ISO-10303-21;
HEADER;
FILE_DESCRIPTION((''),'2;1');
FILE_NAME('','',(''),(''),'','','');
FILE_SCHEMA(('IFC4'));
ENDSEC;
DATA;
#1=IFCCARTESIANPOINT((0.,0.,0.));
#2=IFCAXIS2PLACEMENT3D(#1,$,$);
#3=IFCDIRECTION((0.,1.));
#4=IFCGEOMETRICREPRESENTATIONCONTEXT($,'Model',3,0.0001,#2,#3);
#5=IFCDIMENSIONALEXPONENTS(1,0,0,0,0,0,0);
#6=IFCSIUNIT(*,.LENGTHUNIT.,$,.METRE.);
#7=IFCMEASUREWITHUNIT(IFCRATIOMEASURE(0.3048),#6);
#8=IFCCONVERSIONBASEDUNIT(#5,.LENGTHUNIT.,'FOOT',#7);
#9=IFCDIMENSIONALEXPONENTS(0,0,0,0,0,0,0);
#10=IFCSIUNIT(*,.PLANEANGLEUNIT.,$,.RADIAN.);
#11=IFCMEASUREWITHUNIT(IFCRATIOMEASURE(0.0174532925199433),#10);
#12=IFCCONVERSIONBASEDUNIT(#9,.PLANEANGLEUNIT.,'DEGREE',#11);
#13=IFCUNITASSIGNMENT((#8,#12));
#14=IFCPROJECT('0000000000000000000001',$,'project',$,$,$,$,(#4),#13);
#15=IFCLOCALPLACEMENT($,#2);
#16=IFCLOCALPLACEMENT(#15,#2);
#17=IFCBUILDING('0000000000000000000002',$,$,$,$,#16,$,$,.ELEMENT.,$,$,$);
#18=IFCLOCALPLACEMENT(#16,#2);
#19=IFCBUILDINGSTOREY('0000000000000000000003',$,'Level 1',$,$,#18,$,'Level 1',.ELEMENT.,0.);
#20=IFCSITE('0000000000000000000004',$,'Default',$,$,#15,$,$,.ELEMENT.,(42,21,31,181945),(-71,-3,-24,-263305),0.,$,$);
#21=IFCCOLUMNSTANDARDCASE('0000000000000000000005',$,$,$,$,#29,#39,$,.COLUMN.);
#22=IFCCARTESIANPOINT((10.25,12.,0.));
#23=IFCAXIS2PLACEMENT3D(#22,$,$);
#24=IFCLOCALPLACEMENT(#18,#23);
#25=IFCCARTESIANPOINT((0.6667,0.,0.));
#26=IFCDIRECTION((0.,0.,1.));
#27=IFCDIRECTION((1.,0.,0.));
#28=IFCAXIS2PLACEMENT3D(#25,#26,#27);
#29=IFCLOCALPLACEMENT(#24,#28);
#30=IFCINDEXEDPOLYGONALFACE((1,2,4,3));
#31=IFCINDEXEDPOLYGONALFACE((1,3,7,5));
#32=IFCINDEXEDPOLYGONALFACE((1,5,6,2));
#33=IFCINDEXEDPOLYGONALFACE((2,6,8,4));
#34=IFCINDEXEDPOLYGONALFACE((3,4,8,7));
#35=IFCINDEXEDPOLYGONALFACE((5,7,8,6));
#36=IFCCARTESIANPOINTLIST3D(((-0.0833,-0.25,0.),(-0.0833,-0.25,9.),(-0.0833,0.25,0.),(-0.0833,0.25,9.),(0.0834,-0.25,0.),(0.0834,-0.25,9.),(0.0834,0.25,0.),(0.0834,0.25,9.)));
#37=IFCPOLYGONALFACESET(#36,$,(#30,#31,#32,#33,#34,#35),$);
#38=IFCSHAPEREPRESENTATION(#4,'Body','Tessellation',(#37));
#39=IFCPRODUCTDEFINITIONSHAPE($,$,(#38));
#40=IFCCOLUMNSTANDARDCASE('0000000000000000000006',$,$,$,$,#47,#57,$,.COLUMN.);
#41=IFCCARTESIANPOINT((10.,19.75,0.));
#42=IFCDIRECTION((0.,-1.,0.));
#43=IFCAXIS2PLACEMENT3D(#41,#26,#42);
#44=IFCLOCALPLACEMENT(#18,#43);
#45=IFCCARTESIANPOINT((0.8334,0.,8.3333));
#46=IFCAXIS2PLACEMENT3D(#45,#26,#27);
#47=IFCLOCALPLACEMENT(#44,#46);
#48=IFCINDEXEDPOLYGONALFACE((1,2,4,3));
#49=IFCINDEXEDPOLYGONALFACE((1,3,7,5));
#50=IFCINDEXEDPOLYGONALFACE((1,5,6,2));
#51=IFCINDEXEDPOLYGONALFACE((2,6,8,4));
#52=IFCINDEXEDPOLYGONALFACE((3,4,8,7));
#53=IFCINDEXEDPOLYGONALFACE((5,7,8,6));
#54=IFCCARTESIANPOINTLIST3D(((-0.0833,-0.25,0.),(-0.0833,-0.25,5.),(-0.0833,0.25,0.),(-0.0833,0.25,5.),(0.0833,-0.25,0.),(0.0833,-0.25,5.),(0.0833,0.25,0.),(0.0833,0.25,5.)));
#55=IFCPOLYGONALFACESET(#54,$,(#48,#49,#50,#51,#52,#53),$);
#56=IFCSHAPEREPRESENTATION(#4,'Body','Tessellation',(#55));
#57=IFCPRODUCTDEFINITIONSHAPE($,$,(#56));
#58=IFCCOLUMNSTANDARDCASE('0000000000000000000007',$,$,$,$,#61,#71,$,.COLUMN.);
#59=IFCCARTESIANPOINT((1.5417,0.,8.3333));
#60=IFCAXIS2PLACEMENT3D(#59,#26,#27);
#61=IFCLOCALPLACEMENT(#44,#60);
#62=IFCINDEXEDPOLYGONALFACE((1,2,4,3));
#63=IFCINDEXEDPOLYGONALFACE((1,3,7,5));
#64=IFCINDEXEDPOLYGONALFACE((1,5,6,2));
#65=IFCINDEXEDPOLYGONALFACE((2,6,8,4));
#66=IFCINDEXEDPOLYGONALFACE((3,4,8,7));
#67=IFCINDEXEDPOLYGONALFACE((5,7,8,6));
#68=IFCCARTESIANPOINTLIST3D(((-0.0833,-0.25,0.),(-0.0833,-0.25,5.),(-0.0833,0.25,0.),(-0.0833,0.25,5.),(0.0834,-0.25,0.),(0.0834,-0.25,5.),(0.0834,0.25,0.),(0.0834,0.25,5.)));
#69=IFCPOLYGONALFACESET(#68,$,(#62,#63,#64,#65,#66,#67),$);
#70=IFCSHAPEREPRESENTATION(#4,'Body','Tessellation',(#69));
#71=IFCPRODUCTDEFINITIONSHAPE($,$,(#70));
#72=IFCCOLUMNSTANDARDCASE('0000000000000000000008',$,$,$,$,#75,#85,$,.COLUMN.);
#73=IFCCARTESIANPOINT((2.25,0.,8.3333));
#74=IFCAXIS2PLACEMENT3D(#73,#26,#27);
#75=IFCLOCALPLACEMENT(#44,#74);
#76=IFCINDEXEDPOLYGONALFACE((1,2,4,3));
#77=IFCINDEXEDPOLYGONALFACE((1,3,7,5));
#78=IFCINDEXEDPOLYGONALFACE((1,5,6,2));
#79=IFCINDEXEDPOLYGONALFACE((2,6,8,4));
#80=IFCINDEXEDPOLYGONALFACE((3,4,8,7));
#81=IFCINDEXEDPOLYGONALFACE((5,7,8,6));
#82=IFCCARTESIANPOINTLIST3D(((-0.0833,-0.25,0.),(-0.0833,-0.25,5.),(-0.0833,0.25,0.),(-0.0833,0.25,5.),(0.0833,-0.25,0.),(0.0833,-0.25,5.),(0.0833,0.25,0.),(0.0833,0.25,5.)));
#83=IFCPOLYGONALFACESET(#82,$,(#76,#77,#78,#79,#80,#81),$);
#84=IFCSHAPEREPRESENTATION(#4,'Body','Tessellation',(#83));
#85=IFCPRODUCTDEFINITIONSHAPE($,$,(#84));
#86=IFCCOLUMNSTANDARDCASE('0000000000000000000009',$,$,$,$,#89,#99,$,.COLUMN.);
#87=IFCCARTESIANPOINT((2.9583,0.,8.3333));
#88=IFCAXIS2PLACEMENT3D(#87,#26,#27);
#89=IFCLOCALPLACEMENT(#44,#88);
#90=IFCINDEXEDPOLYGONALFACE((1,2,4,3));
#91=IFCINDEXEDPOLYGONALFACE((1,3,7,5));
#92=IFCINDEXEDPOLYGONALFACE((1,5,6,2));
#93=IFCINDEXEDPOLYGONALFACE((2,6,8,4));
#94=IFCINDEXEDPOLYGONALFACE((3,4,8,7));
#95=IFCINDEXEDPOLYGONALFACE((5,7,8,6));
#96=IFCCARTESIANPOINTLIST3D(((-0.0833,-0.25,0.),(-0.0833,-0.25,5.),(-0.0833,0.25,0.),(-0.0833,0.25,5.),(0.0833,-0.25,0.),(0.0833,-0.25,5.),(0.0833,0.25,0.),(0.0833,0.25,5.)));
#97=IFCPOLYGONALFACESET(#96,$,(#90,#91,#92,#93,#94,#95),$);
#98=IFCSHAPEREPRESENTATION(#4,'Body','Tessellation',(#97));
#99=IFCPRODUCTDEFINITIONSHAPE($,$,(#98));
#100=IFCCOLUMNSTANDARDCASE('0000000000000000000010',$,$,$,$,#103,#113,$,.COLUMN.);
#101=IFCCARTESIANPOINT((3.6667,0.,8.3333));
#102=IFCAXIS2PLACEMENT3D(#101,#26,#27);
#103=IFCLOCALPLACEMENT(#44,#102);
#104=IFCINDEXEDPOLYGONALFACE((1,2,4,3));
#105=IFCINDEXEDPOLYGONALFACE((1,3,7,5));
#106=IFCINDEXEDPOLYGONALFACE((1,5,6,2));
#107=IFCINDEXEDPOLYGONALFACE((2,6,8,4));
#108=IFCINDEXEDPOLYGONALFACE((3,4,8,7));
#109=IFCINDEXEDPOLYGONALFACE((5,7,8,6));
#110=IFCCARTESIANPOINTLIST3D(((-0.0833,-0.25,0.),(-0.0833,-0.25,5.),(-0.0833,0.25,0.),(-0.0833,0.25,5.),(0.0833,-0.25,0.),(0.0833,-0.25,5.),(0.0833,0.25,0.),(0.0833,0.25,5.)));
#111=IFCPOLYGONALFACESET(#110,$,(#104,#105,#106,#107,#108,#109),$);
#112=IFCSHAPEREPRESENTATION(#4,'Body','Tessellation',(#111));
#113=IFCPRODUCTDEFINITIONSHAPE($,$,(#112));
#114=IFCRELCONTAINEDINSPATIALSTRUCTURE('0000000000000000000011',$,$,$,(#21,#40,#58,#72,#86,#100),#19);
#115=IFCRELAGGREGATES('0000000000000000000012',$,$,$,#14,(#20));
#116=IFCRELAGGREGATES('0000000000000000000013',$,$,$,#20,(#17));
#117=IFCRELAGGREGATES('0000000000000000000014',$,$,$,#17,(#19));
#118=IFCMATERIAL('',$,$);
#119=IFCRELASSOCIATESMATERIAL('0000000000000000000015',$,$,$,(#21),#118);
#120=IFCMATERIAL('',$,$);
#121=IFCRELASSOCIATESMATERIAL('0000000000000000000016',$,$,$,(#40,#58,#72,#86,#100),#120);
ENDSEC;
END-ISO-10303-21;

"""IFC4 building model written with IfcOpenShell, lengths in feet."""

from ifc_helpers import new_model, entity, si_unit, converted_unit, direction, frame, origin, place, context, project, spatial, rectangle, extrude, material, element, save


model = new_model("IFC4")

# Units and contexts
model_context = context("Model", 3, precision=0.0001, world=origin(), true_north=direction((0.0, 1.0)))
ifc_project = project(units=[converted_unit("LENGTHUNIT", "FOOT", entity("IfcRatioMeasure", 0.3048), si_unit("LENGTHUNIT", "METRE"), dimensions=[1, 0, 0, 0, 0, 0, 0]), converted_unit("PLANEANGLEUNIT", "DEGREE", entity("IfcRatioMeasure", 0.0174532925199433), si_unit("PLANEANGLEUNIT", "RADIAN"), dimensions=[0, 0, 0, 0, 0, 0, 0])], contexts=[model_context])

# Site, building, storey
site_placement = place(None, origin())
site = spatial("IfcSite", under=ifc_project, at=site_placement, Name="Default", CompositionType="ELEMENT", RefLatitude=(42, 21, 31, 181945), RefLongitude=(-71, -3, -24, -263305), RefElevation=0.0)
building_placement = place(site_placement, origin())
building = spatial("IfcBuilding", under=site, at=building_placement, CompositionType="ELEMENT")
storey_placement = place(building_placement, origin())
storey = spatial("IfcBuildingStorey", under=building, at=storey_placement, Name="Level 1", LongName="Level 1", CompositionType="ELEMENT", Elevation=0.0)

# Columns
ifc_material_1 = material(Name="")
wall_1_placement = place(storey_placement, frame((10.25, 12.0, 0.0)))
for number, where, z_axis, x_axis in (
    (1, (0.6667, 0.0, 0.0), (0.0, 0.0, 1.0), (1.0, 0.0, 0.0)),
):
    element("IfcColumnStandardCase", number, at=place(wall_1_placement, frame(where, z_axis=z_axis, x_axis=x_axis)), inside=storey, material=ifc_material_1, PredefinedType="COLUMN", context=model_context, shape_type="SweptSolid", body=[
        extrude(rectangle(XDim=0.1667, YDim=0.5), origin(), (0.0, 0.0, 1.0), 9.0),
    ])
wall_2_placement = place(storey_placement, frame((10.0, 19.75, 0.0), z_axis=(0.0, 0.0, 1.0), x_axis=(0.0, -1.0, 0.0)))
ifc_material_2 = material(Name="")
for number, where, z_axis, x_axis in (
    (2, (0.8334, 0.0, 8.3333), (0.0, 0.0, 1.0), (1.0, 0.0, 0.0)),
    (3, (1.5417, 0.0, 8.3333), (0.0, 0.0, 1.0), (1.0, 0.0, 0.0)),
    (4, (2.25, 0.0, 8.3333), (0.0, 0.0, 1.0), (1.0, 0.0, 0.0)),
    (5, (2.9583, 0.0, 8.3333), (0.0, 0.0, 1.0), (1.0, 0.0, 0.0)),
    (6, (3.6667, 0.0, 8.3333), (0.0, 0.0, 1.0), (1.0, 0.0, 0.0)),
):
    element("IfcColumnStandardCase", number, at=place(wall_2_placement, frame(where, z_axis=z_axis, x_axis=x_axis)), inside=storey, material=ifc_material_2, PredefinedType="COLUMN", context=model_context, shape_type="SweptSolid", body=[
        extrude(rectangle(XDim=0.1667, YDim=0.5), origin(), (0.0, 0.0, 1.0), 5.0),
    ])

save(model, "model.ifc")
